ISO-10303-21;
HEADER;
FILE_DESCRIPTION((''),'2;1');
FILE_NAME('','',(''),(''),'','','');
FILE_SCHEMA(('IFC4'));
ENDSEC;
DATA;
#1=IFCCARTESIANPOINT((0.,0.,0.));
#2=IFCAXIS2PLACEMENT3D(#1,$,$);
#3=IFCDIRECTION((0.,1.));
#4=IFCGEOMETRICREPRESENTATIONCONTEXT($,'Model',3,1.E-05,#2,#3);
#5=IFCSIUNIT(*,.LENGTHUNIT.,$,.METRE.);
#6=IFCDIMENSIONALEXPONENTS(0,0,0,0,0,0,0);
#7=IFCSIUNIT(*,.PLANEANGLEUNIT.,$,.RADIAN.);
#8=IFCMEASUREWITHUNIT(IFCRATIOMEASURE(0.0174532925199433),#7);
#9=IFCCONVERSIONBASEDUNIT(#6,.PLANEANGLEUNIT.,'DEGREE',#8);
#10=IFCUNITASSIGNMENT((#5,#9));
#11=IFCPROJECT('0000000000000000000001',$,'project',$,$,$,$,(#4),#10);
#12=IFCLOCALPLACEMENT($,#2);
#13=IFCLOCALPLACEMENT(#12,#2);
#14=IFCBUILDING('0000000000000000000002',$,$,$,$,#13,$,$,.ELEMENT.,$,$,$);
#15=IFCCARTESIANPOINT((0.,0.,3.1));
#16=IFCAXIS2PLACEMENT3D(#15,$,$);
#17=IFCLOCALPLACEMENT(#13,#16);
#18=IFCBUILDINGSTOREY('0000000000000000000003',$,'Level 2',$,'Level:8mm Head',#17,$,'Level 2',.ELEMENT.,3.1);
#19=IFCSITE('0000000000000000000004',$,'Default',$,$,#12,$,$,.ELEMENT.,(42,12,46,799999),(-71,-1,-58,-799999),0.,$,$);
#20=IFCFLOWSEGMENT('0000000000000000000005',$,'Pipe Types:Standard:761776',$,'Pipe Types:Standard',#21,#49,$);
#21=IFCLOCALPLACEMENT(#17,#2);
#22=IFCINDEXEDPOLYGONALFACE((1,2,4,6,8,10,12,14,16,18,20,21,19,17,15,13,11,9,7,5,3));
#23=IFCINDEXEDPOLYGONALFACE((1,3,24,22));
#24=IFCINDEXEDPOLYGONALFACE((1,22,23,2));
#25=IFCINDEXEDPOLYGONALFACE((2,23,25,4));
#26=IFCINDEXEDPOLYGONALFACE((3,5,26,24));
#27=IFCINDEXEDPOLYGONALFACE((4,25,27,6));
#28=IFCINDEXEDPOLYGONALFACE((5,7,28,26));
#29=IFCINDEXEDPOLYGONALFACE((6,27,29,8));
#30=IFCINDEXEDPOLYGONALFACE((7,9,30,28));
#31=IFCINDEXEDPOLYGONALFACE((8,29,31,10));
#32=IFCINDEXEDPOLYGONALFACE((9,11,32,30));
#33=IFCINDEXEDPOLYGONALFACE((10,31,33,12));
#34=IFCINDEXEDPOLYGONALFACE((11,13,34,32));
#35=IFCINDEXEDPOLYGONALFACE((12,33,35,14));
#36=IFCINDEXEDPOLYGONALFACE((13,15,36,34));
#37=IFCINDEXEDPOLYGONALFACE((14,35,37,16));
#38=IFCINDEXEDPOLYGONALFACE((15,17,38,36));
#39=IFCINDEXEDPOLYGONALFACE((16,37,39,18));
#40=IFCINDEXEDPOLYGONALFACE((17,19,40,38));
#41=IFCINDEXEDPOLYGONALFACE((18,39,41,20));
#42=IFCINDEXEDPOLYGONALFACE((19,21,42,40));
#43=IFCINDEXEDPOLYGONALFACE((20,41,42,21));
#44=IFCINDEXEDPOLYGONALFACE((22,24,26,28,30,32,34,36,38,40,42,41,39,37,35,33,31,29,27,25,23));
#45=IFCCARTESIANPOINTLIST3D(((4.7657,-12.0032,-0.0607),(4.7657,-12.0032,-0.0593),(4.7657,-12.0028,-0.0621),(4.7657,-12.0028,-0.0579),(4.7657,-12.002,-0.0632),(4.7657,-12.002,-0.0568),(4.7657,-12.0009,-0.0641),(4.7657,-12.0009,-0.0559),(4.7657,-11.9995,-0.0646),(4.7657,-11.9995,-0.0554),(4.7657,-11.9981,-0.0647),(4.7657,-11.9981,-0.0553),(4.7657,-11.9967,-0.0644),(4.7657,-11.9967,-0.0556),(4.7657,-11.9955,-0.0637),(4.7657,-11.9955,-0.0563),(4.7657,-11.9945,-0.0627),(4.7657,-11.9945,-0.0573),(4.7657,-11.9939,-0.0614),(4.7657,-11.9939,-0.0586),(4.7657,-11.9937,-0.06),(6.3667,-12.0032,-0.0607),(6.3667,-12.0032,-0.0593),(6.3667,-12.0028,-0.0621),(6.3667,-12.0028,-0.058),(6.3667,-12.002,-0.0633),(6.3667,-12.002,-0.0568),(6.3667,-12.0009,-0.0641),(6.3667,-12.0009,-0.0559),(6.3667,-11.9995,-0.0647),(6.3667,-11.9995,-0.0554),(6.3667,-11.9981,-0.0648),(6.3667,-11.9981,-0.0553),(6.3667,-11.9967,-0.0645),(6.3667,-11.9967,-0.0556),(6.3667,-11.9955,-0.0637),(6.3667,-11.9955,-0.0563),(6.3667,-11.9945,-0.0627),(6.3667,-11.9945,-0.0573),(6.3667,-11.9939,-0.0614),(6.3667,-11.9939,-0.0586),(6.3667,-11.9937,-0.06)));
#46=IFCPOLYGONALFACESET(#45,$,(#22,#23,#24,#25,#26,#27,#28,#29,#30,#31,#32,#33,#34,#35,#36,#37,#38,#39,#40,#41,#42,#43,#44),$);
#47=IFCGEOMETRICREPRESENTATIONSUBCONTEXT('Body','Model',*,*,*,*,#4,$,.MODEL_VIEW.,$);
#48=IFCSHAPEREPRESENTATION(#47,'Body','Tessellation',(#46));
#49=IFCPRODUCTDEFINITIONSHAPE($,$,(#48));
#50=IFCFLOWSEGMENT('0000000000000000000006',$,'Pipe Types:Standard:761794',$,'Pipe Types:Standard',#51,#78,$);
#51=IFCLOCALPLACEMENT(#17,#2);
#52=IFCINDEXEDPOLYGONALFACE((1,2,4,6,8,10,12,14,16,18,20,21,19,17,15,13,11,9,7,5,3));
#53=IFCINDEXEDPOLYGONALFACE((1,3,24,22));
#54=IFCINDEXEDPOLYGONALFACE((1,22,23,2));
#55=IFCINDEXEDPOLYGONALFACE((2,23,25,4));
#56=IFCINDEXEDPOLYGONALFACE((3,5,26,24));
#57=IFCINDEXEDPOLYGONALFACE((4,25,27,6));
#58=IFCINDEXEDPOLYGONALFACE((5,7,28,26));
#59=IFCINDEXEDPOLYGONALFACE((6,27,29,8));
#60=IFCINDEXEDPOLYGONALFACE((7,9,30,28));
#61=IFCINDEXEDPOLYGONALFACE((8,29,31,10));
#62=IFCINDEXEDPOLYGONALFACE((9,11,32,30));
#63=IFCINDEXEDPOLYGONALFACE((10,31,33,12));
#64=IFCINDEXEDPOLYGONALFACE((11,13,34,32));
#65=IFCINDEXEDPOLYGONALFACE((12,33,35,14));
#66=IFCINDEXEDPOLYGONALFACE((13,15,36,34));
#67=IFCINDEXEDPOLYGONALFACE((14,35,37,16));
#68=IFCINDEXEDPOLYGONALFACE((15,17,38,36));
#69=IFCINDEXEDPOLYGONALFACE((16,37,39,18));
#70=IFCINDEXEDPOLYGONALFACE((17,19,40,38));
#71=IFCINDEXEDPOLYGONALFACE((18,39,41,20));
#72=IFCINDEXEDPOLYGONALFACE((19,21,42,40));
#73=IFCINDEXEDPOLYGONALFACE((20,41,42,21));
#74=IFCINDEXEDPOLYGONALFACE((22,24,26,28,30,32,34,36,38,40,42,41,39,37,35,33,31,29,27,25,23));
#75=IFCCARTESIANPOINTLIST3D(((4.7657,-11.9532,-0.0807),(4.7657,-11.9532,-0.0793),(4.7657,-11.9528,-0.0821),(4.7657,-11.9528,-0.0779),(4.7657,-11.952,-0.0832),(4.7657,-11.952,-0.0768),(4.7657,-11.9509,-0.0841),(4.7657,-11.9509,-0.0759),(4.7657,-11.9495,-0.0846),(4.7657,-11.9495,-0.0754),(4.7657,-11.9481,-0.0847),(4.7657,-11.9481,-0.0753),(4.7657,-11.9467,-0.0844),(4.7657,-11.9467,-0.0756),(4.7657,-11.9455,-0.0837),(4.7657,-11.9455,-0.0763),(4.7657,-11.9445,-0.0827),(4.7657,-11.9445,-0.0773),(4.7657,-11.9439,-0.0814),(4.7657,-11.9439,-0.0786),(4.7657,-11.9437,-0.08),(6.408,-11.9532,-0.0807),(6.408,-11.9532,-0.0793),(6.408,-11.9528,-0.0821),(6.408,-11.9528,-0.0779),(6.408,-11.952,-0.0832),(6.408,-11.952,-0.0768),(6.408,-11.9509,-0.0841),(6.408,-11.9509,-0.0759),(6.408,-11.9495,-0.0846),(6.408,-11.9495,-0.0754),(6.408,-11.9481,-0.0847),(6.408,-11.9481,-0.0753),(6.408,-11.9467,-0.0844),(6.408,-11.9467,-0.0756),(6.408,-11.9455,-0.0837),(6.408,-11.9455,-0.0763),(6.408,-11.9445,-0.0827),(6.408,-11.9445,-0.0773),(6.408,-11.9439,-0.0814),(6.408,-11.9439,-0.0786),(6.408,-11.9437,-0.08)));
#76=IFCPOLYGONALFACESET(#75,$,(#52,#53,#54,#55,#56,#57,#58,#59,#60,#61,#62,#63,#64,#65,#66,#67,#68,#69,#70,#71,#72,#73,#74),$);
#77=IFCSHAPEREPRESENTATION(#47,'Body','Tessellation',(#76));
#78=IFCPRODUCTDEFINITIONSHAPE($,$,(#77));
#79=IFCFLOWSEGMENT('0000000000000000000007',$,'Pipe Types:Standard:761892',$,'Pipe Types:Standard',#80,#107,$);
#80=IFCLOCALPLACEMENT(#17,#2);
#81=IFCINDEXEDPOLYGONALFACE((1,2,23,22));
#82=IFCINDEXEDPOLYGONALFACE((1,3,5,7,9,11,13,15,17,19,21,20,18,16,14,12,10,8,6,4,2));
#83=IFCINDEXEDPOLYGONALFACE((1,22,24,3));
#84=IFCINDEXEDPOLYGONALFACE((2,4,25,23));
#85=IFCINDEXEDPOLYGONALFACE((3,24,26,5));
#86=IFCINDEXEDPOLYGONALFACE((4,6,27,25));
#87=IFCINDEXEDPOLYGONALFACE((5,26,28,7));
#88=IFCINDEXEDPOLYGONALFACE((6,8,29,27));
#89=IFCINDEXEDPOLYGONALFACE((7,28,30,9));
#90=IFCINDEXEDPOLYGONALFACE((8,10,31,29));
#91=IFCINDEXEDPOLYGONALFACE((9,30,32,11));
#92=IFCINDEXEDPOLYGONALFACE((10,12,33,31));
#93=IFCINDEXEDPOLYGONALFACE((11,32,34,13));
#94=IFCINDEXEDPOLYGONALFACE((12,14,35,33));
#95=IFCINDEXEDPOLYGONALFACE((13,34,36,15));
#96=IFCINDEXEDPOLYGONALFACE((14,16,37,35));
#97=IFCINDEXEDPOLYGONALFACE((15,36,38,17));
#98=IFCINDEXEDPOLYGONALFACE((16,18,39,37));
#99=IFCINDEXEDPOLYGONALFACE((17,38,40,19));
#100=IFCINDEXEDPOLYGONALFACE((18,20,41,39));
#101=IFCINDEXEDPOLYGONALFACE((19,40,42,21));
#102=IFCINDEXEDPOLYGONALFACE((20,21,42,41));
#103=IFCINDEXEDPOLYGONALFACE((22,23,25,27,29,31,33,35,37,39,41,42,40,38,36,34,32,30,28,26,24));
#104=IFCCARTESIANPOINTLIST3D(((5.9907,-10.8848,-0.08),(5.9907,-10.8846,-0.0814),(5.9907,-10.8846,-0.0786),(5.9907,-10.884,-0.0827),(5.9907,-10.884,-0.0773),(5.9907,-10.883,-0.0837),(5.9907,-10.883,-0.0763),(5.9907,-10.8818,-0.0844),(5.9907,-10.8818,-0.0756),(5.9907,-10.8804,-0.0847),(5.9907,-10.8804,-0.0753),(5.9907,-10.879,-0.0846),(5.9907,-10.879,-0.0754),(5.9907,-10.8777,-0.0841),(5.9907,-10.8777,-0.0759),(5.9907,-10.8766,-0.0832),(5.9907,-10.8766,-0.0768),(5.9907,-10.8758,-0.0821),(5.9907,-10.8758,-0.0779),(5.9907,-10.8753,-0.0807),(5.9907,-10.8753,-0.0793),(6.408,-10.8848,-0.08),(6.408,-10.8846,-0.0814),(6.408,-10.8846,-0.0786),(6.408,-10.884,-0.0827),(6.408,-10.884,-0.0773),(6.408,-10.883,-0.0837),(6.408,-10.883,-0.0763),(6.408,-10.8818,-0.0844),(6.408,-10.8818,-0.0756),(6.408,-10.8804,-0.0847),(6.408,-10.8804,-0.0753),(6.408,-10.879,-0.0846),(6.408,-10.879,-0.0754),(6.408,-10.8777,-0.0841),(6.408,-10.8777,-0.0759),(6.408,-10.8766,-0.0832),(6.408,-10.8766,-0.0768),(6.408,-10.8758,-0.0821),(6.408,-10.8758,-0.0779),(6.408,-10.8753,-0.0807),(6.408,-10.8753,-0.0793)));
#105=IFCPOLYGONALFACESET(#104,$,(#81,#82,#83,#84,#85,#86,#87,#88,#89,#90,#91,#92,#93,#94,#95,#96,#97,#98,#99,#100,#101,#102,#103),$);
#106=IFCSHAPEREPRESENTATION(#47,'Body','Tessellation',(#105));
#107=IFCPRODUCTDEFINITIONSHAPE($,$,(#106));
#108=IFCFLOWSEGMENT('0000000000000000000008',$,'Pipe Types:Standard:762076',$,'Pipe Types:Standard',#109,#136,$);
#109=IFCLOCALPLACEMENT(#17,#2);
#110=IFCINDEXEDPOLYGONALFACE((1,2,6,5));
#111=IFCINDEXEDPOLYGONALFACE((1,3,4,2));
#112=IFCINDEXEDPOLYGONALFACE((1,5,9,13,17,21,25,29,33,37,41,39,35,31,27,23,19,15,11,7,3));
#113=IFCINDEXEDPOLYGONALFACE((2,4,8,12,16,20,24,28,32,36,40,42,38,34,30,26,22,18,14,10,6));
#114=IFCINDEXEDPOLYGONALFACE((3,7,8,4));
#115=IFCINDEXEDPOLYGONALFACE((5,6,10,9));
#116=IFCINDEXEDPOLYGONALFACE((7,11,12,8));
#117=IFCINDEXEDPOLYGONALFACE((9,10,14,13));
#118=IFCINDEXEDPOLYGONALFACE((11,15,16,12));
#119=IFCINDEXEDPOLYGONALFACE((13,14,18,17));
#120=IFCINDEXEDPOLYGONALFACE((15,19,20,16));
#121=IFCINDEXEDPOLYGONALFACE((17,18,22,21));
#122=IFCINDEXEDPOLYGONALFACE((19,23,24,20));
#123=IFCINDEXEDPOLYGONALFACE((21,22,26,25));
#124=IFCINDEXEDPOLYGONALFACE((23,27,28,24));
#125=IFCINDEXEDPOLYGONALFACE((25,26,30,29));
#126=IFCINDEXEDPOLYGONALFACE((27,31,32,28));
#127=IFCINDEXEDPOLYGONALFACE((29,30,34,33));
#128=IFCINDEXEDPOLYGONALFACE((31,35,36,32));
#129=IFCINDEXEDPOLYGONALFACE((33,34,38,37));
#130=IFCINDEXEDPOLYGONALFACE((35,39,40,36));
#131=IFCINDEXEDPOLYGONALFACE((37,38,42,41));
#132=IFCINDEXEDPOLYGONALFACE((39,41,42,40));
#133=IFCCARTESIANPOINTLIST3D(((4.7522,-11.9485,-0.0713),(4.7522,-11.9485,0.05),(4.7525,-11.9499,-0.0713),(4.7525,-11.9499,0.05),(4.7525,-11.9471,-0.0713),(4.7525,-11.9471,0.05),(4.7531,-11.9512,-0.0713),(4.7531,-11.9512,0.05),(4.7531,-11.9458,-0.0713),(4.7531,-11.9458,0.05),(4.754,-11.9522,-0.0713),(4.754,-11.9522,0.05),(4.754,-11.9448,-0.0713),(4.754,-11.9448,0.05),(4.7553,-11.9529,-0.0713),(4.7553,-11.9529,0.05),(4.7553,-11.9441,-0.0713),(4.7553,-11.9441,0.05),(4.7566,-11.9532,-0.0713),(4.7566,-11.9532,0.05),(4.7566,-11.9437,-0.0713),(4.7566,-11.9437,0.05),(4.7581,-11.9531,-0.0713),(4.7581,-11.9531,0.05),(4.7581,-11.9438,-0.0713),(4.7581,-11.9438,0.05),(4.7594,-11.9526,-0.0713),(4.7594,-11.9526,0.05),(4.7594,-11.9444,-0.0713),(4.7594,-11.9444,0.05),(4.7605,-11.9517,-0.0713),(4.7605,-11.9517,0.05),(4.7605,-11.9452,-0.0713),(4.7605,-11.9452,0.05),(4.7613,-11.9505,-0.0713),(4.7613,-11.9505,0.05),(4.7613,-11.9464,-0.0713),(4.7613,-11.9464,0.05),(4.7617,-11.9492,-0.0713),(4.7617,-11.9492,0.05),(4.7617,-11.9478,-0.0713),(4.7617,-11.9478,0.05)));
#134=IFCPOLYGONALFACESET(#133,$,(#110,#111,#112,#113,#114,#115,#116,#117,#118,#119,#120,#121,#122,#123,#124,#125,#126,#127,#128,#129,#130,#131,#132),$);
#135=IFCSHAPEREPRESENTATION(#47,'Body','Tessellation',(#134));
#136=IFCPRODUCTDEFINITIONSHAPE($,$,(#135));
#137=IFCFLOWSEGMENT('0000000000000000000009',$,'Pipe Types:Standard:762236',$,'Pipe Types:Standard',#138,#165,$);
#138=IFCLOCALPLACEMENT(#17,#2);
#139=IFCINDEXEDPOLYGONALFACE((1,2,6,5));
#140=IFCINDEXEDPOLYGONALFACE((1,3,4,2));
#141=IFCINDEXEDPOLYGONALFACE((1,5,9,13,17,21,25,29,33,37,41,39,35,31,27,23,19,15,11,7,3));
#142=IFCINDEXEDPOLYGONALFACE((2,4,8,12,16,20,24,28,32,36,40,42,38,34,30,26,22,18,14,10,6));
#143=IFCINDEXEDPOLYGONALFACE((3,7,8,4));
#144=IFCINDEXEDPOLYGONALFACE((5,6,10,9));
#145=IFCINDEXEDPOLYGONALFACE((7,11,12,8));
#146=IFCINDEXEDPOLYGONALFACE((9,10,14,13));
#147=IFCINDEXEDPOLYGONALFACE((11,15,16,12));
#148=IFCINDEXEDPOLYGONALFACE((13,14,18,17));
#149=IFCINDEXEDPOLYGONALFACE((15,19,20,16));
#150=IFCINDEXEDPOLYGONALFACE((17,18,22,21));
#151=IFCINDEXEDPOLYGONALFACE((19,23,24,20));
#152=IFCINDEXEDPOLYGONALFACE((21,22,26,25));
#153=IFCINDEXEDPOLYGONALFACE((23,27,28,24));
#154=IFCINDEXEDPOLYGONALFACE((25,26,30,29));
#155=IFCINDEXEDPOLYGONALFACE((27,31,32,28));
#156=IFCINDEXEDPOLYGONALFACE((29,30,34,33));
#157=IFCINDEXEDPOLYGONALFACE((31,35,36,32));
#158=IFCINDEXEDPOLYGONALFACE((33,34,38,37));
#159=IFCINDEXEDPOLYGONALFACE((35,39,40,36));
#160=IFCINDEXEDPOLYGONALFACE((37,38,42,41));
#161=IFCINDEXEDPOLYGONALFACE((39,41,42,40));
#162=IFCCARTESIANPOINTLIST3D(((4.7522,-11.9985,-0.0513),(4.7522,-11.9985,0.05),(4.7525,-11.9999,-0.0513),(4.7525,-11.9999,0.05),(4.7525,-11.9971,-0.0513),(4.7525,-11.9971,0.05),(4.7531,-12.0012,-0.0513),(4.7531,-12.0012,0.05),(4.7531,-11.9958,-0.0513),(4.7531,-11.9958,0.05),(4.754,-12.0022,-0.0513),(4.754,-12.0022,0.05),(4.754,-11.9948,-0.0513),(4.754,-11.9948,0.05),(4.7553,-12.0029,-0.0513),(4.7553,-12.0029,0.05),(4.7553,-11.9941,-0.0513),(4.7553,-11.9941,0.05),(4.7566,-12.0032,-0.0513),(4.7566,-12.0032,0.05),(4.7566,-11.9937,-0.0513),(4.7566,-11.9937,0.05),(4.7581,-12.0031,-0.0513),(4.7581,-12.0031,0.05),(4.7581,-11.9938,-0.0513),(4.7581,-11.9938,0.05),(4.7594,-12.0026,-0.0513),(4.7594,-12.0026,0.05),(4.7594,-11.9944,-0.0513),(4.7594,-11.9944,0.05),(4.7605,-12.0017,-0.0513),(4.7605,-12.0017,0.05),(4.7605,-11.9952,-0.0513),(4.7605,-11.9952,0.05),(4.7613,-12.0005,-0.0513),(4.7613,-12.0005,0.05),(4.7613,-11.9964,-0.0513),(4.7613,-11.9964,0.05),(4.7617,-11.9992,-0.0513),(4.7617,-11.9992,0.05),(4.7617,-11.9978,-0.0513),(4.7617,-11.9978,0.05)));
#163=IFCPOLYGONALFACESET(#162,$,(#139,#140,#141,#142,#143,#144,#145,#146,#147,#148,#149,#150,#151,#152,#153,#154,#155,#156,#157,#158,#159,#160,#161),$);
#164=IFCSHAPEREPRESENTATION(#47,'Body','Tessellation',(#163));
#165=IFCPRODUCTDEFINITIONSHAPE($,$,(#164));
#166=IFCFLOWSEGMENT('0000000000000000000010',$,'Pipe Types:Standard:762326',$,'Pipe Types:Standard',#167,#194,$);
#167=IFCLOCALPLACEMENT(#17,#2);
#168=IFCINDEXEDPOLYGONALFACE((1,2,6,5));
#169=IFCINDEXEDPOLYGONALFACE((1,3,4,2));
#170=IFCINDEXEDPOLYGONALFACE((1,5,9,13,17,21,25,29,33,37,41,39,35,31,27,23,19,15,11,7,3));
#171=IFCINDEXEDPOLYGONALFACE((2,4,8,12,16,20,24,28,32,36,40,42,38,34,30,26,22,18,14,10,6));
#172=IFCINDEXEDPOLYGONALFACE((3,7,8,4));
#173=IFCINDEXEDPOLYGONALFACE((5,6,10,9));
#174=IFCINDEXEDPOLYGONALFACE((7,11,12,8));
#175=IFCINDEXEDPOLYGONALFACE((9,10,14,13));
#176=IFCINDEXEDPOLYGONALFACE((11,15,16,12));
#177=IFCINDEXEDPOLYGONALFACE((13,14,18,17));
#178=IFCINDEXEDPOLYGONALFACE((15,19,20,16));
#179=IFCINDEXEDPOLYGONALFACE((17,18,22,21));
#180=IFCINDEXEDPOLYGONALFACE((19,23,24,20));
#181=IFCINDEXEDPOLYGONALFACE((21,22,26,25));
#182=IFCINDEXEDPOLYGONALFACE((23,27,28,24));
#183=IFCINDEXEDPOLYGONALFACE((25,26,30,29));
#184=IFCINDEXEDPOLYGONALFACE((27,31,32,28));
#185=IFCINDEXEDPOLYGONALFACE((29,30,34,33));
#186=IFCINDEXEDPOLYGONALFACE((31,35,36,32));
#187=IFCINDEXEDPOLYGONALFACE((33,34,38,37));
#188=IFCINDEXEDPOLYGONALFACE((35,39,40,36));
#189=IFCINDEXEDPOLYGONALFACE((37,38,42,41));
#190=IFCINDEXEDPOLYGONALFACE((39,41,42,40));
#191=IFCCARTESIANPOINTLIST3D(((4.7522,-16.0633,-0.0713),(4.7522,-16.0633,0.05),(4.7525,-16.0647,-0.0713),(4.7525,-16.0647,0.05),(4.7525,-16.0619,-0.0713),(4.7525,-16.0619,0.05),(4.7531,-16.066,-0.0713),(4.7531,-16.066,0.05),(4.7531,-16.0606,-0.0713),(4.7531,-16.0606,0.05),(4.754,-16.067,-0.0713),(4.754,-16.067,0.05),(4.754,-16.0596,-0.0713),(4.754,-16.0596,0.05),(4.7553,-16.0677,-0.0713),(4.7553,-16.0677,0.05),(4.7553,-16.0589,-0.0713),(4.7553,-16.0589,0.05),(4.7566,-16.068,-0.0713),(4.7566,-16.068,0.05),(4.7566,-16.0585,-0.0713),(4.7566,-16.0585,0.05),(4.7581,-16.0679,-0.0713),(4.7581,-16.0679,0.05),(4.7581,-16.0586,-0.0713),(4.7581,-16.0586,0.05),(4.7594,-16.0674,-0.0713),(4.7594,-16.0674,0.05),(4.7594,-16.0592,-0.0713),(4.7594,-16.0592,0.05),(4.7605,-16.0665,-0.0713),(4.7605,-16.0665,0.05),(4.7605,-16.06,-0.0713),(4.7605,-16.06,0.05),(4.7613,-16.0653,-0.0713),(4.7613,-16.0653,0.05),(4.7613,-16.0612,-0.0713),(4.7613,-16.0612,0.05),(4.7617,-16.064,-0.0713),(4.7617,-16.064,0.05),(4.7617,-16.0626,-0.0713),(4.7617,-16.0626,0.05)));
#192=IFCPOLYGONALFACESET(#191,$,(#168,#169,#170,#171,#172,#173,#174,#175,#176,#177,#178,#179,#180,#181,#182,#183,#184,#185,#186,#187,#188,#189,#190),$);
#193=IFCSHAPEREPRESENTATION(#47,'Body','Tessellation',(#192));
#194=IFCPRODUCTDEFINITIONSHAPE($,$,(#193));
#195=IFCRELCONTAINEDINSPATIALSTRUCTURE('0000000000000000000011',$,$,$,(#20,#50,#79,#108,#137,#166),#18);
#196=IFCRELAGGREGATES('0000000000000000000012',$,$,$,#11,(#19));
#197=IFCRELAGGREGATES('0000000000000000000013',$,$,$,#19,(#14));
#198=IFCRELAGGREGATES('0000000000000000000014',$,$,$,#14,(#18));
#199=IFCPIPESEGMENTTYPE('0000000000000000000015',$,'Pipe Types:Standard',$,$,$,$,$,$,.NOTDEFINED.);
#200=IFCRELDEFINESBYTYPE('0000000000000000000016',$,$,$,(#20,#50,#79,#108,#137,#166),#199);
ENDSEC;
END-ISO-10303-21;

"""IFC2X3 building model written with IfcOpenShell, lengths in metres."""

from ifc_helpers import new_model, entity, si_unit, converted_unit, direction, frame, frame_2d, origin, origin_2d_with_axis, place, context, subcontext, project, spatial, circle, extrude, type_object, element, save


model = new_model("IFC2X3")

# Units and contexts
model_context = context("Model", 3, precision=1e-05, world=origin(), true_north=direction((0.0, 1.0)))
body_context = subcontext(model_context, "Body", "Model", "MODEL_VIEW")
ifc_project = project(units=[si_unit("LENGTHUNIT", "METRE"), converted_unit("PLANEANGLEUNIT", "DEGREE", entity("IfcRatioMeasure", 0.0174532925199433), si_unit("PLANEANGLEUNIT", "RADIAN"), dimensions=[0, 0, 0, 0, 0, 0, 0])], contexts=[model_context])

# Site, building, storey
site_placement = place(None, origin())
site = spatial("IfcSite", under=ifc_project, at=site_placement, Name="Default", CompositionType="ELEMENT", RefLatitude=(42, 12, 46, 799999), RefLongitude=(-71, -1, -58, -799999), RefElevation=0.0)
building_placement = place(site_placement, origin())
building = spatial("IfcBuilding", under=site, at=building_placement, CompositionType="ELEMENT")
storey_placement = place(building_placement, frame((0.0, 0.0, 3.1)))
storey = spatial("IfcBuildingStorey", under=building, at=storey_placement, Name="Level 2", ObjectType="Level:8mm Head", LongName="Level 2", CompositionType="ELEMENT", Elevation=3.1)

# Flow segments
pipe_segment_type = type_object("IfcPipeSegmentType", Name="Pipe Types:Standard", PredefinedType="NOTDEFINED")
flow_segment_1_placement = place(storey_placement, origin())
element("IfcFlowSegment", 1, at=flow_segment_1_placement, inside=storey, type_object=pipe_segment_type, Name="Pipe Types:Standard:761776", ObjectType="Pipe Types:Standard", context=body_context, shape_type="SweptSolid", body=[
    extrude(circle(Radius=0.0048, at=origin_2d_with_axis()), frame((4.7657, -11.9985, -0.06), z_axis=(1.0, 0.0, -0.000015), x_axis=(0.0, 1.0, 0.0)), (0.0, 0.0, 1.0), 1.601),
])
flow_segment_2_placement = place(storey_placement, origin())
element("IfcFlowSegment", 2, at=flow_segment_2_placement, inside=storey, type_object=pipe_segment_type, Name="Pipe Types:Standard:761794", ObjectType="Pipe Types:Standard", context=body_context, shape_type="SweptSolid", body=[
    extrude(circle(Radius=0.0048, at=frame_2d((0.0, 0.0), x_axis=(1.0, 0.0))), frame((4.7657, -11.9485, -0.08), z_axis=(1.0, 0.0, 0.0), x_axis=(0.0, 1.0, 0.0)), (0.0, 0.0, 1.0), 1.6423),
])
flow_segment_3_placement = place(storey_placement, origin())
element("IfcFlowSegment", 3, at=flow_segment_3_placement, inside=storey, type_object=pipe_segment_type, Name="Pipe Types:Standard:761892", ObjectType="Pipe Types:Standard", context=body_context, shape_type="SweptSolid", body=[
    extrude(circle(Radius=0.0048, at=origin_2d_with_axis()), frame((5.9907, -10.8801, -0.08), z_axis=(1.0, 0.0, 0.0), x_axis=(0.0, -1.0, 0.0)), (0.0, 0.0, 1.0), 0.4173),
])
flow_segment_4_placement = place(storey_placement, origin())
element("IfcFlowSegment", 4, at=flow_segment_4_placement, inside=storey, type_object=pipe_segment_type, Name="Pipe Types:Standard:762076", ObjectType="Pipe Types:Standard", context=body_context, shape_type="SweptSolid", body=[
    extrude(circle(Radius=0.0048, at=frame_2d((0.0, 0.0), x_axis=(1.0, 0.0))), frame((4.757, -11.9485, -0.0713), z_axis=(0.0, 0.0, 1.0), x_axis=(-1.0, 0.0, 0.0)), (0.0, 0.0, 1.0), 0.1213),
])
flow_segment_5_placement = place(storey_placement, origin())
element("IfcFlowSegment", 5, at=flow_segment_5_placement, inside=storey, type_object=pipe_segment_type, Name="Pipe Types:Standard:762236", ObjectType="Pipe Types:Standard", context=body_context, shape_type="SweptSolid", body=[
    extrude(circle(Radius=0.0048, at=origin_2d_with_axis()), frame((4.757, -11.9985, -0.0513), z_axis=(0.0, 0.0, 1.0), x_axis=(-1.0, 0.0, 0.0)), (0.0, 0.0, 1.0), 0.1013),
])
flow_segment_6_placement = place(storey_placement, origin())
element("IfcFlowSegment", 6, at=flow_segment_6_placement, inside=storey, type_object=pipe_segment_type, Name="Pipe Types:Standard:762326", ObjectType="Pipe Types:Standard", context=body_context, shape_type="SweptSolid", body=[
    extrude(circle(Radius=0.0048, at=origin_2d_with_axis()), frame((4.757, -16.0633, -0.0713), z_axis=(0.0, 0.0, 1.0), x_axis=(-1.0, 0.0, 0.0)), (0.0, 0.0, 1.0), 0.1213),
])

save(model, "model.ifc")
